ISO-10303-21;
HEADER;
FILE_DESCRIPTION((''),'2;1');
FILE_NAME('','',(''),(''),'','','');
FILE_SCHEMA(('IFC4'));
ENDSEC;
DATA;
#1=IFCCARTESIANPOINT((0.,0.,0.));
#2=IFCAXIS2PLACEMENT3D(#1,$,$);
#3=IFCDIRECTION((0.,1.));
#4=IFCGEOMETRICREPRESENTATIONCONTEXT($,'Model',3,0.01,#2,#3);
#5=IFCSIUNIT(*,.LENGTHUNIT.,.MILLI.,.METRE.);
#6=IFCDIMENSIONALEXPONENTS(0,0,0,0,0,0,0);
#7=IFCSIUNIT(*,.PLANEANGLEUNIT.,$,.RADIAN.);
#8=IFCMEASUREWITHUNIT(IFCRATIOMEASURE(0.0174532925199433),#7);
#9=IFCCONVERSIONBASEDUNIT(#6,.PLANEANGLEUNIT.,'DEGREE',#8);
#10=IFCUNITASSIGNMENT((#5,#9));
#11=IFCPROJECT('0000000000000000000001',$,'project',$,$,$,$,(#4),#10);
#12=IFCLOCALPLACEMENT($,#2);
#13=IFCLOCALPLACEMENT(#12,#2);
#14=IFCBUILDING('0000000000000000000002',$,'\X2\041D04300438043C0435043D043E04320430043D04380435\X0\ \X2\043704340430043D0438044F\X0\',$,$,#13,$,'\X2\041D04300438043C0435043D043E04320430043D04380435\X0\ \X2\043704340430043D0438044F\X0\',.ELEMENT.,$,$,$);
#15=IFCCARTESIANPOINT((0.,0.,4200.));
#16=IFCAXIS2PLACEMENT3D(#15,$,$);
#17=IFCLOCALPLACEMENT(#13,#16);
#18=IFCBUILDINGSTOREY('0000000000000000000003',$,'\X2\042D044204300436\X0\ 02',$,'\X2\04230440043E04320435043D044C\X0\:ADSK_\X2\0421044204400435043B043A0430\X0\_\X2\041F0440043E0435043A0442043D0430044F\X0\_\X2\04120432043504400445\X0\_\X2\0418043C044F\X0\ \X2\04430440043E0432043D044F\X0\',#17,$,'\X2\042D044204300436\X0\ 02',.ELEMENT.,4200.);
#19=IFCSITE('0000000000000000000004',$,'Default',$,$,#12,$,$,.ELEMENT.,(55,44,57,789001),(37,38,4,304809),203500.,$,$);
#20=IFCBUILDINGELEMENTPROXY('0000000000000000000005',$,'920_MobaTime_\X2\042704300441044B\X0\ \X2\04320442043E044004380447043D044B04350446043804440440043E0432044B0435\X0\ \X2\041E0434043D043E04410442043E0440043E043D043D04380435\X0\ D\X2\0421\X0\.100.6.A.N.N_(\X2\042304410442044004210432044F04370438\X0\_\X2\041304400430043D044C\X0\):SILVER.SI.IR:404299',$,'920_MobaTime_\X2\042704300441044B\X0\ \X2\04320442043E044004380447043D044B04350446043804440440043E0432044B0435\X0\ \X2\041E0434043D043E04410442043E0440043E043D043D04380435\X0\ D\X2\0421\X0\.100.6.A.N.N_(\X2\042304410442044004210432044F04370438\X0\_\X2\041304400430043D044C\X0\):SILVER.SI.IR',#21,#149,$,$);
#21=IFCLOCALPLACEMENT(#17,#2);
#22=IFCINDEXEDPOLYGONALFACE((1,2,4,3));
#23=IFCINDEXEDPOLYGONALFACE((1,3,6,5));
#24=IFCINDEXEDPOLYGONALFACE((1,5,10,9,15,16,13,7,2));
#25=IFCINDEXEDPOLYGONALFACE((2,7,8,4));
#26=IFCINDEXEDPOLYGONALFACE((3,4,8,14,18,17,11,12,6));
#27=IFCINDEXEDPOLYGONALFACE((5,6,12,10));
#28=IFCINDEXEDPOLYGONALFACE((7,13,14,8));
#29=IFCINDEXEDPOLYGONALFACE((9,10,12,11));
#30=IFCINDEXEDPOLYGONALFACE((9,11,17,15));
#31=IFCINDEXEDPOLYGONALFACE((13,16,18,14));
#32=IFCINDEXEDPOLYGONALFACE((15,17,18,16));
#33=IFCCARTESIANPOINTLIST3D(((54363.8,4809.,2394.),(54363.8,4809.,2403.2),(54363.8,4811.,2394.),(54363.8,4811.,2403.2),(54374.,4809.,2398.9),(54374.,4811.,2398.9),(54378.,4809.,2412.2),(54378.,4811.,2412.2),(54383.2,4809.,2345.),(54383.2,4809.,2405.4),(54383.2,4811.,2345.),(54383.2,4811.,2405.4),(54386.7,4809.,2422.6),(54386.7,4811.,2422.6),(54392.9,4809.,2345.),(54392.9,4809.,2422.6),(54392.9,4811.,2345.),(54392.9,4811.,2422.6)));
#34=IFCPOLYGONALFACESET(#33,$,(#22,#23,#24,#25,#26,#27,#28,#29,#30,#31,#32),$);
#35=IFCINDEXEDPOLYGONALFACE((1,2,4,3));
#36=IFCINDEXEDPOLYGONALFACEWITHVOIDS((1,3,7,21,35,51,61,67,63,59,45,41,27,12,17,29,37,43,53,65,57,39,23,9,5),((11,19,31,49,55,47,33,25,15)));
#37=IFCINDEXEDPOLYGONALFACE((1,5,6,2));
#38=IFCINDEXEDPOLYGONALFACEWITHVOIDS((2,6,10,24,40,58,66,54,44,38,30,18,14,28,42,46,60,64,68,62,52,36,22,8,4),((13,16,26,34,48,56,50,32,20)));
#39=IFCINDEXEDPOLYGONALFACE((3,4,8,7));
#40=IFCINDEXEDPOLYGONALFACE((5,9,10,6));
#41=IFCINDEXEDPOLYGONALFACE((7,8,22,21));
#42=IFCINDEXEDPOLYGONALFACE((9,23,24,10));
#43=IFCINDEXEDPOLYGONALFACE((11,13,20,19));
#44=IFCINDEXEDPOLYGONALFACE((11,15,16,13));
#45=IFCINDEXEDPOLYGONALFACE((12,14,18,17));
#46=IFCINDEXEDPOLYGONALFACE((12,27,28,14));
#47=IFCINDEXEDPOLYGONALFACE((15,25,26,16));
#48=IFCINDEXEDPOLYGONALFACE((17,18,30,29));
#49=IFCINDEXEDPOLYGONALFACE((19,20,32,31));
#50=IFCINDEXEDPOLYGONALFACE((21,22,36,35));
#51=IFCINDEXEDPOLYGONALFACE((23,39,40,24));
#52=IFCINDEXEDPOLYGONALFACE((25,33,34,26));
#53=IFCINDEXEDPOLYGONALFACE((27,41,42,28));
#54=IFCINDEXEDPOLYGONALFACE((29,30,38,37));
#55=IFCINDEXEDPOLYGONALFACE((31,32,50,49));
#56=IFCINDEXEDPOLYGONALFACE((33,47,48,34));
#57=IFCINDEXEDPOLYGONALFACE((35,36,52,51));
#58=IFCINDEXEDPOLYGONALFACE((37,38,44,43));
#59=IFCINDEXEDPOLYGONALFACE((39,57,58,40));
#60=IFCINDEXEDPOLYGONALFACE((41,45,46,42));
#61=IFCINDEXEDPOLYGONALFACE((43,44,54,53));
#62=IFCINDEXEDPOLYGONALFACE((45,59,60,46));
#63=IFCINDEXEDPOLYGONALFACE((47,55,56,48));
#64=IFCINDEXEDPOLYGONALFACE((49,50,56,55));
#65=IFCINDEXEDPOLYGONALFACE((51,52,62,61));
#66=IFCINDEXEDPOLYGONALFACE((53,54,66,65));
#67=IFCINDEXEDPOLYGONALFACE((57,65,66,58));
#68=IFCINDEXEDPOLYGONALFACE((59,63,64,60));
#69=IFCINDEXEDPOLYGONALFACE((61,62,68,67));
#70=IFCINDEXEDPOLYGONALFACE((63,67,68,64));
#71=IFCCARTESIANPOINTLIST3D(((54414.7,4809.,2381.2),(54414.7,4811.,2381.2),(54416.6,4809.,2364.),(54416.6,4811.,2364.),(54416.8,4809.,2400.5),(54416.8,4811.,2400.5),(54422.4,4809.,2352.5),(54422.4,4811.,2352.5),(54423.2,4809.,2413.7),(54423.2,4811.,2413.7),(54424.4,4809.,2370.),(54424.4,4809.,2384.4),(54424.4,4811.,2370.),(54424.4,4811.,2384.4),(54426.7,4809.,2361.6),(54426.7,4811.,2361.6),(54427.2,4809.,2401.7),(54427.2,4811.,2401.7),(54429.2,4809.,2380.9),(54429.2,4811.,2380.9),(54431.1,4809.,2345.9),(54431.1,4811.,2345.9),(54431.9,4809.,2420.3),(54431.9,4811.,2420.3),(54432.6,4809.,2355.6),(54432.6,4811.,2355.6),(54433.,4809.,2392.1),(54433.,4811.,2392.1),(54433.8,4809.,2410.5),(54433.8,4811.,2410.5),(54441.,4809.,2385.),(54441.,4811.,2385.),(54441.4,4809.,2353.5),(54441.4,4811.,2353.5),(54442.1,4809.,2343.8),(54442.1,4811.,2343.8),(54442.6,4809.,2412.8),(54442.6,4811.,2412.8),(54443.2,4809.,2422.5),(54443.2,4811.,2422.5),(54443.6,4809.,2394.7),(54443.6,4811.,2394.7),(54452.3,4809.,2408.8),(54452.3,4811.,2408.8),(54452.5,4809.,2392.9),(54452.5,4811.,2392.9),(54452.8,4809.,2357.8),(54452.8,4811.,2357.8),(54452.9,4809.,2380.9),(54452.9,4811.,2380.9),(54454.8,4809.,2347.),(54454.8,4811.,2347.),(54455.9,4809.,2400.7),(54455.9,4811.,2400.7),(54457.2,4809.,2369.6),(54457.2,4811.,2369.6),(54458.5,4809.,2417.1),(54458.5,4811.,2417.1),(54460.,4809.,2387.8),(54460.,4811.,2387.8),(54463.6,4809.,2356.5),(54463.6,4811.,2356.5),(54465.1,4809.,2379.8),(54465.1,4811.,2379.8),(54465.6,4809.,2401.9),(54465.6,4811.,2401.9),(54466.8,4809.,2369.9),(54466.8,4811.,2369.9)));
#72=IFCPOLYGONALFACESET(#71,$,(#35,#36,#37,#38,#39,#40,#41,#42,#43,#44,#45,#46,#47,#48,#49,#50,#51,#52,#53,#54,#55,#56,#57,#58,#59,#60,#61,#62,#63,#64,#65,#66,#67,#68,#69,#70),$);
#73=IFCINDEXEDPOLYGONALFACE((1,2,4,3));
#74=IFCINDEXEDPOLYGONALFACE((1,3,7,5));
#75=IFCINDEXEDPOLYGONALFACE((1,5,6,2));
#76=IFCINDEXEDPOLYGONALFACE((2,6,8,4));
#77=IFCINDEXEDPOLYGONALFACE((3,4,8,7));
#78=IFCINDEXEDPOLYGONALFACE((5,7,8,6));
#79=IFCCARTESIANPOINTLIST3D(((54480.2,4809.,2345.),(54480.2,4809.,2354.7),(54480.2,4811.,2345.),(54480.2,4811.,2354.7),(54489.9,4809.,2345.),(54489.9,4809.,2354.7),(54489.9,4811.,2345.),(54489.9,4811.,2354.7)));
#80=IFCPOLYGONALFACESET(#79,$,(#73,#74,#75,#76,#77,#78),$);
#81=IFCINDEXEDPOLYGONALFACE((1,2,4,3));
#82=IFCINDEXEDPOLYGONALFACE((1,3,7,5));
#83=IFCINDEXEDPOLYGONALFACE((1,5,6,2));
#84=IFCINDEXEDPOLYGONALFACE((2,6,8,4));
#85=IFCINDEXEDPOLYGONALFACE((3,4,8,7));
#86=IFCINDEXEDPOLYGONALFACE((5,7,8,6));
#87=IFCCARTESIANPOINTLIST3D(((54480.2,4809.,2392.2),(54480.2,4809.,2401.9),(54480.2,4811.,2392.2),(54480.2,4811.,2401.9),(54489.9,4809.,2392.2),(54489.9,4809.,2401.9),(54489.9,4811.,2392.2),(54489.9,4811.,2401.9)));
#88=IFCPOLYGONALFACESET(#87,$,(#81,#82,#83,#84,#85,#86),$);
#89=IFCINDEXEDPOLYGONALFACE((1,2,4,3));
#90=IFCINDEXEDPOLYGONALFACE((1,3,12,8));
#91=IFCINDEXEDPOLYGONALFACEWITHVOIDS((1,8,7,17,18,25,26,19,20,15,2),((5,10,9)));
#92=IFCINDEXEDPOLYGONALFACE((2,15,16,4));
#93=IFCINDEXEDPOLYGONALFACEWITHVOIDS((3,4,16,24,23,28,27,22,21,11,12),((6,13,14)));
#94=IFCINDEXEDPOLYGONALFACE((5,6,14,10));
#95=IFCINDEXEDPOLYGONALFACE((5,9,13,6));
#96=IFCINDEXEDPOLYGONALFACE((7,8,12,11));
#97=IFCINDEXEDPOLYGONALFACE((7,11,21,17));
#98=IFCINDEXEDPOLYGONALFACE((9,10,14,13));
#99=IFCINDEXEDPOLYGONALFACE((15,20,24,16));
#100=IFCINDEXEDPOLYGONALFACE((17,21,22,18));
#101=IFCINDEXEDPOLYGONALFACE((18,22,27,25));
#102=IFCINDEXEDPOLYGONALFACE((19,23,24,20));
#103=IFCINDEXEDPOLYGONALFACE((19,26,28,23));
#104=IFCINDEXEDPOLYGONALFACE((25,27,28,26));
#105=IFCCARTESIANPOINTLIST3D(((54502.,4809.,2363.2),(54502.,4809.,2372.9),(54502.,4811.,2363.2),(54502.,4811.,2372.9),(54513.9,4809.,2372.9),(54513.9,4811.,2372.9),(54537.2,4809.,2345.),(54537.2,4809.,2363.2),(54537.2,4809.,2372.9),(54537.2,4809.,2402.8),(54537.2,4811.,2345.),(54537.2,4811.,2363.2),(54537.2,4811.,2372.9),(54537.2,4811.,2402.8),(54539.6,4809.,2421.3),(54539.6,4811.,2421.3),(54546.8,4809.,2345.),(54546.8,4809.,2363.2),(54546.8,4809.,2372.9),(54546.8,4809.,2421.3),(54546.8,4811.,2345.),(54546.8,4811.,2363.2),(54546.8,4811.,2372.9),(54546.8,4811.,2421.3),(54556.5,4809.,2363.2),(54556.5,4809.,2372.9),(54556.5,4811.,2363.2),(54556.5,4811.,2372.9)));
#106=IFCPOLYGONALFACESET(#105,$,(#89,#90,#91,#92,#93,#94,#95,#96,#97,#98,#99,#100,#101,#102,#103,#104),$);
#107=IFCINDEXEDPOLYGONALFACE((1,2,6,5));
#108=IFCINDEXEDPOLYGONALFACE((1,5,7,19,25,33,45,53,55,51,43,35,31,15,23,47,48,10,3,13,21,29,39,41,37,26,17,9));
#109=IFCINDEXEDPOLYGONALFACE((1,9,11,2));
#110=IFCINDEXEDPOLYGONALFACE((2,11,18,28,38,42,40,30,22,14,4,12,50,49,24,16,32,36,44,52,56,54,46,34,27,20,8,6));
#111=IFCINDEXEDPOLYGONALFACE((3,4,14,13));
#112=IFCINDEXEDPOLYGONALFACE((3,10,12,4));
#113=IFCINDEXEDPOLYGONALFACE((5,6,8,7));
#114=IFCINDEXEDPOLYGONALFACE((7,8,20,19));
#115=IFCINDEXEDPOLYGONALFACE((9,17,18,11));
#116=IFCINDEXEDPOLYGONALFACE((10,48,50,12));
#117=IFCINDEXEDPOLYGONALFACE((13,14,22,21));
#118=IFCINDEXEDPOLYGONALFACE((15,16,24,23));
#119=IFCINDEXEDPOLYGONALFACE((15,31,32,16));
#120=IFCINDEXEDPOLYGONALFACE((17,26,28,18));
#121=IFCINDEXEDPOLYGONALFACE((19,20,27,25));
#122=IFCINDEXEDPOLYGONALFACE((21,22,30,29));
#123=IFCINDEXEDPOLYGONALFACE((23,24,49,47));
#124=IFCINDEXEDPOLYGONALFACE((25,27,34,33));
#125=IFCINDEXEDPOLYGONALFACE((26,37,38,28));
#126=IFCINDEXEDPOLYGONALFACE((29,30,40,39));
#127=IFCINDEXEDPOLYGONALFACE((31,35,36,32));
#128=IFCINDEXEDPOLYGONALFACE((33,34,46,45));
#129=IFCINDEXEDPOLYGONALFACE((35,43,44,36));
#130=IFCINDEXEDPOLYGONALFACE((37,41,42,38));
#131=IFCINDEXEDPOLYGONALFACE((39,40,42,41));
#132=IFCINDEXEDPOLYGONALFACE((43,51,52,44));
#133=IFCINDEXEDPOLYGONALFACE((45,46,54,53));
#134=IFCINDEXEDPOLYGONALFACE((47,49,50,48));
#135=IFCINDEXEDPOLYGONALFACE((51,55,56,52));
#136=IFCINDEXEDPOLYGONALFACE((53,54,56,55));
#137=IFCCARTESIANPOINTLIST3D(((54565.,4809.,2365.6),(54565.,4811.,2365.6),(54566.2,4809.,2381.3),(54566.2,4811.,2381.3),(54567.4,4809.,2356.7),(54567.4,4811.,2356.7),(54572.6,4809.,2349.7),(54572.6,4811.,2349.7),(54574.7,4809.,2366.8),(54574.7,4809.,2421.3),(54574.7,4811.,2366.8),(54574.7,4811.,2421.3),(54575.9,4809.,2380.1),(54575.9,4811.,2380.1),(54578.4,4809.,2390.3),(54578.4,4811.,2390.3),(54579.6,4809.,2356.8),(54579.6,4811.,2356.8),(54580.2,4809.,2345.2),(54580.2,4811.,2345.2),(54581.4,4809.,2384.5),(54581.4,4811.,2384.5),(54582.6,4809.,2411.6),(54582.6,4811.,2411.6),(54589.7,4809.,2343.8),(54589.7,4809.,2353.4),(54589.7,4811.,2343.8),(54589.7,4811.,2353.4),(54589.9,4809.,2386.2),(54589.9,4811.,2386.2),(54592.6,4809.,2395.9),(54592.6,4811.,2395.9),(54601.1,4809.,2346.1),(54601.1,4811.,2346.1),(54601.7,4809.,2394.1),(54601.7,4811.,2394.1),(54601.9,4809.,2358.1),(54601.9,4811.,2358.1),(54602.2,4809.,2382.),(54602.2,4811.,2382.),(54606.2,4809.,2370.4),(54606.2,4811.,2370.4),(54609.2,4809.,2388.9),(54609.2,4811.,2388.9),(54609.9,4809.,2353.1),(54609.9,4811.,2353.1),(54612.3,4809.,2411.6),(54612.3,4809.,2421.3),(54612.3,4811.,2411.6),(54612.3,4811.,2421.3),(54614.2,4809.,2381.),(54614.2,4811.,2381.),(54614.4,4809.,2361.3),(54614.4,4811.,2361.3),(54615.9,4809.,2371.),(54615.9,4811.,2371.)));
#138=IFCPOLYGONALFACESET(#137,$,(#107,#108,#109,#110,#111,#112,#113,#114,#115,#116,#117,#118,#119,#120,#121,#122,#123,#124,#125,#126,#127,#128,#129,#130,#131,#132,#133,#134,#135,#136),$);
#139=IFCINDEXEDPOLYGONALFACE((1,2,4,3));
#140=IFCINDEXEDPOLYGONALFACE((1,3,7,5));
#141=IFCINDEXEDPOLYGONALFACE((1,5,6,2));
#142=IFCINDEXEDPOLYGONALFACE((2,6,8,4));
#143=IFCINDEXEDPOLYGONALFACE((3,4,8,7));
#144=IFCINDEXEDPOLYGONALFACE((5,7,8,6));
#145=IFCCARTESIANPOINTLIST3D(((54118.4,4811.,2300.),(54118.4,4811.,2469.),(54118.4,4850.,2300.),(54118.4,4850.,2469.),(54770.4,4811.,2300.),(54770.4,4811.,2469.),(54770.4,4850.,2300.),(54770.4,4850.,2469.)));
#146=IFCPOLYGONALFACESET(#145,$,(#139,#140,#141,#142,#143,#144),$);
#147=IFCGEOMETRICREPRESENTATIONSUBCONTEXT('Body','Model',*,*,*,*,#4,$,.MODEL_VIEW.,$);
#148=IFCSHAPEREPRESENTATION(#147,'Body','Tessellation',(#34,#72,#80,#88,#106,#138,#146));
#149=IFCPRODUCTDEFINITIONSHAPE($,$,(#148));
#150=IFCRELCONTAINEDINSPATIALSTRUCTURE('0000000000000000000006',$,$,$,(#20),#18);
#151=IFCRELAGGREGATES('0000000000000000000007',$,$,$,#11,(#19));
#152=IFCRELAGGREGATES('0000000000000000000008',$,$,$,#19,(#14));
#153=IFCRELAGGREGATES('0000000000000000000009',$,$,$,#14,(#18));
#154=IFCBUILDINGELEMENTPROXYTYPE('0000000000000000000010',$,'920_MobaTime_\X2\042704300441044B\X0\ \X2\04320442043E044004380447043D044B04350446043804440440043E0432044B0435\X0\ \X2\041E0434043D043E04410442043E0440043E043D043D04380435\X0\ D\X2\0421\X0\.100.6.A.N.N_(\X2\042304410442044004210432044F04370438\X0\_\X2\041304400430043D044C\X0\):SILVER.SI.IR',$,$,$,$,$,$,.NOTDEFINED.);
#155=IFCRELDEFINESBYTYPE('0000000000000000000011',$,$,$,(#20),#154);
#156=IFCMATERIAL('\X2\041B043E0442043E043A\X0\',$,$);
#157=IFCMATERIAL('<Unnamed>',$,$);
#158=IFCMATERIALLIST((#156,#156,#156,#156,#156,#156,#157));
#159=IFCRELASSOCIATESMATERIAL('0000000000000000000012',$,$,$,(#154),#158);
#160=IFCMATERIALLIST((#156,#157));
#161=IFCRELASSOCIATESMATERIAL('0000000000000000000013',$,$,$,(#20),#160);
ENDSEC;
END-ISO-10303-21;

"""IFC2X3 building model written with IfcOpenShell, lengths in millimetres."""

from ifc_helpers import new_model, entity, si_unit, converted_unit, direction, frame, origin, origin_2d_with_axis, place, context, subcontext, project, spatial, polyline, rectangle, outline, extrude, source, transform, mapped, material, material_list, type_object, type_shapes, element, save


model = new_model("IFC2X3")

# Units and contexts
model_context = context("Model", 3, precision=0.01, world=origin(), true_north=direction((0.0, 1.0)))
body_context = subcontext(model_context, "Body", "Model", "MODEL_VIEW")
ifc_project = project(units=[si_unit("LENGTHUNIT", "METRE", prefix="MILLI"), converted_unit("PLANEANGLEUNIT", "DEGREE", entity("IfcRatioMeasure", 0.0174532925199433), si_unit("PLANEANGLEUNIT", "RADIAN"), dimensions=[0, 0, 0, 0, 0, 0, 0])], contexts=[model_context])

# Site, building, storey
site_placement = place(None, origin())
site = spatial("IfcSite", under=ifc_project, at=site_placement, Name="Default", CompositionType="ELEMENT", RefLatitude=(55, 44, 57, 789001), RefLongitude=(37, 38, 4, 304809), RefElevation=203500.0)
building_placement = place(site_placement, origin())
building = spatial("IfcBuilding", under=site, at=building_placement, Name="Наименование здания", LongName="Наименование здания", CompositionType="ELEMENT")
storey_placement = place(building_placement, frame((0.0, 0.0, 4200.0)))
storey = spatial("IfcBuildingStorey", under=building, at=storey_placement, Name="Этаж 02", ObjectType="Уровень:ADSK_Стрелка_Проектная_Вверх_Имя уровня", LongName="Этаж 02", CompositionType="ELEMENT", Elevation=4200.0)

# Building element proxy
ifc_material_1 = material(Name="Лоток")
ifc_material_2 = material(Name="<Unnamed>")
ifc_material_list_1 = material_list([ifc_material_1, ifc_material_2])
ifc_material_list_2 = material_list([ifc_material_1, ifc_material_1, ifc_material_1, ifc_material_1, ifc_material_1, ifc_material_1, ifc_material_2])
building_element_proxy_type_1 = type_object("IfcBuildingElementProxyType", Name="920_MobaTime_Часы вторичныецифровые Односторонние DС.100.6.A.N.N_(УстрСвязи_Грань):SILVER.SI.IR", PredefinedType="NOTDEFINED", material=ifc_material_list_2)
shared_shape_1 = source(origin(), body_context, "Body", "SweptSolid", [
    extrude(outline(polyline([(-49.3, -13.1), (28.2, -13.1), (28.2, -6.8), (17.9, 1.8), (8.8, 16.0), (-0.3, 16.0), (4.6, 5.8), (11.1, -3.4), (-49.3, -3.4), (-49.3, -13.1)])), frame((-64.6, 9.8, 39.0), z_axis=(0.0, 0.0, 1.0), x_axis=(0.0, 1.0, 0.0)), (0.0, 0.0, 1.0), 2.0),
    extrude(outline(polyline([(2.2, -27.6), (19.0, -27.6), (30.5, -16.1), (33.3, -4.9), (31.0, 5.8), (21.8, 17.2), (5.2, 27.3), (-11.1, 33.0), (-24.0, 32.7), (-33.6, 27.6), (-40.3, 18.6), (-42.8, 5.7), (-38.0, -6.3), (-27.2, -14.9), (-17.5, -17.7), (-8.2, -16.4), (-0.3, -11.9), (5.1, -4.5), (7.3, 6.2), (4.0, 17.2), (18.4, 7.3), (23.6, -2.4), (22.0, -11.4), (14.2, -18.4), (5.3, -18.3), (2.2, -27.6)]), holes=[polyline([(-9.0, 23.3), (-1.3, 14.3), (-2.5, 2.0), (-11.4, -7.0), (-23.4, -6.0), (-32.2, 2.9), (-31.2, 15.1), (-25.6, 22.1), (-17.5, 24.9), (-9.0, 23.3)])]), frame((-2.7, 3.6, 39.0), z_axis=(0.0, 0.0, 1.0), x_axis=(-0.427649, 0.903945, 0.0)), (0.0, 0.0, 1.0), 2.0),
    extrude(rectangle(XDim=9.7, YDim=9.7, at=origin_2d_with_axis()), frame((40.6, -34.7, 39.0)), (0.0, 0.0, 1.0), 2.0),
    extrude(rectangle(XDim=9.7, YDim=9.7, at=origin_2d_with_axis()), frame((40.6, 12.6, 39.0)), (0.0, 0.0, 1.0), 2.0),
    extrude(outline(polyline([(-0.9, -28.1), (8.8, -28.1), (8.8, -9.9), (18.5, -9.9), (18.5, -0.2), (8.8, -0.2), (8.8, 48.3), (1.5, 48.3), (-36.0, -0.2), (-36.0, -9.9), (-0.9, -9.9), (-0.9, -28.1)]), holes=[polyline([(-0.9, -0.2), (-24.1, -0.2), (-0.9, 29.7), (-0.9, -0.2)])]), frame((93.6, -11.4, 39.0)), (0.0, 0.0, 1.0), 2.0),
    extrude(outline(polyline([(3.3, -28.3), (12.5, -28.3), (20.5, -25.0), (26.8, -18.9), (30.7, -10.0), (31.4, 1.6), (26.9, 11.8), (20.1, 18.4), (11.1, 22.3), (1.0, 23.3), (-7.9, 20.4), (-14.9, 14.5), (-18.9, 6.2), (-17.1, -9.0), (-36.7, 0.5), (-29.1, 29.2), (-38.5, 31.7), (-48.1, -4.6), (-11.6, -23.1), (-8.0, -14.0), (-10.8, -7.6), (-10.2, 1.1), (-3.0, 11.8), (9.2, 12.8), (20.0, 5.5), (21.4, -7.5), (15.5, -16.4), (4.6, -18.6), (3.3, -28.3)])), frame((147.1, -8.5, 39.0), z_axis=(0.0, 0.0, 1.0), x_axis=(0.256974, -0.966418, 0.0)), (0.0, 0.0, 1.0), 2.0),
    extrude(rectangle(XDim=652.0, YDim=169.0, at=origin_2d_with_axis()), frame((0.0, 0.0, 0.0), z_axis=(0.0, 0.0, 1.0), x_axis=(-1.0, 0.0, 0.0)), (0.0, 0.0, 1.0), 39.0),
])
type_shapes(building_element_proxy_type_1, [shared_shape_1])
for number, where, z_axis, x_axis, name in (
    (1, (54444.4, 4850.0, 2384.5), (0.0, -1.0, 0.0), (1.0, 0.0, 0.0), "920_MobaTime_Часы вторичныецифровые Односторонние DС.100.6.A.N.N_(УстрСвязи_Грань):SILVER.SI.IR:404299"),
):
    element("IfcBuildingElementProxy", number, at=place(storey_placement, frame(where, z_axis=z_axis, x_axis=x_axis)), inside=storey, type_object=building_element_proxy_type_1, material=ifc_material_list_1, Name=name, ObjectType="920_MobaTime_Часы вторичныецифровые Односторонние DС.100.6.A.N.N_(УстрСвязи_Грань):SILVER.SI.IR", context=body_context, shape_type="MappedRepresentation", body=[
        mapped(shared_shape_1, transform((0.0, 0.0, 0.0), scale=1.0)),
    ])

save(model, "model.ifc")
